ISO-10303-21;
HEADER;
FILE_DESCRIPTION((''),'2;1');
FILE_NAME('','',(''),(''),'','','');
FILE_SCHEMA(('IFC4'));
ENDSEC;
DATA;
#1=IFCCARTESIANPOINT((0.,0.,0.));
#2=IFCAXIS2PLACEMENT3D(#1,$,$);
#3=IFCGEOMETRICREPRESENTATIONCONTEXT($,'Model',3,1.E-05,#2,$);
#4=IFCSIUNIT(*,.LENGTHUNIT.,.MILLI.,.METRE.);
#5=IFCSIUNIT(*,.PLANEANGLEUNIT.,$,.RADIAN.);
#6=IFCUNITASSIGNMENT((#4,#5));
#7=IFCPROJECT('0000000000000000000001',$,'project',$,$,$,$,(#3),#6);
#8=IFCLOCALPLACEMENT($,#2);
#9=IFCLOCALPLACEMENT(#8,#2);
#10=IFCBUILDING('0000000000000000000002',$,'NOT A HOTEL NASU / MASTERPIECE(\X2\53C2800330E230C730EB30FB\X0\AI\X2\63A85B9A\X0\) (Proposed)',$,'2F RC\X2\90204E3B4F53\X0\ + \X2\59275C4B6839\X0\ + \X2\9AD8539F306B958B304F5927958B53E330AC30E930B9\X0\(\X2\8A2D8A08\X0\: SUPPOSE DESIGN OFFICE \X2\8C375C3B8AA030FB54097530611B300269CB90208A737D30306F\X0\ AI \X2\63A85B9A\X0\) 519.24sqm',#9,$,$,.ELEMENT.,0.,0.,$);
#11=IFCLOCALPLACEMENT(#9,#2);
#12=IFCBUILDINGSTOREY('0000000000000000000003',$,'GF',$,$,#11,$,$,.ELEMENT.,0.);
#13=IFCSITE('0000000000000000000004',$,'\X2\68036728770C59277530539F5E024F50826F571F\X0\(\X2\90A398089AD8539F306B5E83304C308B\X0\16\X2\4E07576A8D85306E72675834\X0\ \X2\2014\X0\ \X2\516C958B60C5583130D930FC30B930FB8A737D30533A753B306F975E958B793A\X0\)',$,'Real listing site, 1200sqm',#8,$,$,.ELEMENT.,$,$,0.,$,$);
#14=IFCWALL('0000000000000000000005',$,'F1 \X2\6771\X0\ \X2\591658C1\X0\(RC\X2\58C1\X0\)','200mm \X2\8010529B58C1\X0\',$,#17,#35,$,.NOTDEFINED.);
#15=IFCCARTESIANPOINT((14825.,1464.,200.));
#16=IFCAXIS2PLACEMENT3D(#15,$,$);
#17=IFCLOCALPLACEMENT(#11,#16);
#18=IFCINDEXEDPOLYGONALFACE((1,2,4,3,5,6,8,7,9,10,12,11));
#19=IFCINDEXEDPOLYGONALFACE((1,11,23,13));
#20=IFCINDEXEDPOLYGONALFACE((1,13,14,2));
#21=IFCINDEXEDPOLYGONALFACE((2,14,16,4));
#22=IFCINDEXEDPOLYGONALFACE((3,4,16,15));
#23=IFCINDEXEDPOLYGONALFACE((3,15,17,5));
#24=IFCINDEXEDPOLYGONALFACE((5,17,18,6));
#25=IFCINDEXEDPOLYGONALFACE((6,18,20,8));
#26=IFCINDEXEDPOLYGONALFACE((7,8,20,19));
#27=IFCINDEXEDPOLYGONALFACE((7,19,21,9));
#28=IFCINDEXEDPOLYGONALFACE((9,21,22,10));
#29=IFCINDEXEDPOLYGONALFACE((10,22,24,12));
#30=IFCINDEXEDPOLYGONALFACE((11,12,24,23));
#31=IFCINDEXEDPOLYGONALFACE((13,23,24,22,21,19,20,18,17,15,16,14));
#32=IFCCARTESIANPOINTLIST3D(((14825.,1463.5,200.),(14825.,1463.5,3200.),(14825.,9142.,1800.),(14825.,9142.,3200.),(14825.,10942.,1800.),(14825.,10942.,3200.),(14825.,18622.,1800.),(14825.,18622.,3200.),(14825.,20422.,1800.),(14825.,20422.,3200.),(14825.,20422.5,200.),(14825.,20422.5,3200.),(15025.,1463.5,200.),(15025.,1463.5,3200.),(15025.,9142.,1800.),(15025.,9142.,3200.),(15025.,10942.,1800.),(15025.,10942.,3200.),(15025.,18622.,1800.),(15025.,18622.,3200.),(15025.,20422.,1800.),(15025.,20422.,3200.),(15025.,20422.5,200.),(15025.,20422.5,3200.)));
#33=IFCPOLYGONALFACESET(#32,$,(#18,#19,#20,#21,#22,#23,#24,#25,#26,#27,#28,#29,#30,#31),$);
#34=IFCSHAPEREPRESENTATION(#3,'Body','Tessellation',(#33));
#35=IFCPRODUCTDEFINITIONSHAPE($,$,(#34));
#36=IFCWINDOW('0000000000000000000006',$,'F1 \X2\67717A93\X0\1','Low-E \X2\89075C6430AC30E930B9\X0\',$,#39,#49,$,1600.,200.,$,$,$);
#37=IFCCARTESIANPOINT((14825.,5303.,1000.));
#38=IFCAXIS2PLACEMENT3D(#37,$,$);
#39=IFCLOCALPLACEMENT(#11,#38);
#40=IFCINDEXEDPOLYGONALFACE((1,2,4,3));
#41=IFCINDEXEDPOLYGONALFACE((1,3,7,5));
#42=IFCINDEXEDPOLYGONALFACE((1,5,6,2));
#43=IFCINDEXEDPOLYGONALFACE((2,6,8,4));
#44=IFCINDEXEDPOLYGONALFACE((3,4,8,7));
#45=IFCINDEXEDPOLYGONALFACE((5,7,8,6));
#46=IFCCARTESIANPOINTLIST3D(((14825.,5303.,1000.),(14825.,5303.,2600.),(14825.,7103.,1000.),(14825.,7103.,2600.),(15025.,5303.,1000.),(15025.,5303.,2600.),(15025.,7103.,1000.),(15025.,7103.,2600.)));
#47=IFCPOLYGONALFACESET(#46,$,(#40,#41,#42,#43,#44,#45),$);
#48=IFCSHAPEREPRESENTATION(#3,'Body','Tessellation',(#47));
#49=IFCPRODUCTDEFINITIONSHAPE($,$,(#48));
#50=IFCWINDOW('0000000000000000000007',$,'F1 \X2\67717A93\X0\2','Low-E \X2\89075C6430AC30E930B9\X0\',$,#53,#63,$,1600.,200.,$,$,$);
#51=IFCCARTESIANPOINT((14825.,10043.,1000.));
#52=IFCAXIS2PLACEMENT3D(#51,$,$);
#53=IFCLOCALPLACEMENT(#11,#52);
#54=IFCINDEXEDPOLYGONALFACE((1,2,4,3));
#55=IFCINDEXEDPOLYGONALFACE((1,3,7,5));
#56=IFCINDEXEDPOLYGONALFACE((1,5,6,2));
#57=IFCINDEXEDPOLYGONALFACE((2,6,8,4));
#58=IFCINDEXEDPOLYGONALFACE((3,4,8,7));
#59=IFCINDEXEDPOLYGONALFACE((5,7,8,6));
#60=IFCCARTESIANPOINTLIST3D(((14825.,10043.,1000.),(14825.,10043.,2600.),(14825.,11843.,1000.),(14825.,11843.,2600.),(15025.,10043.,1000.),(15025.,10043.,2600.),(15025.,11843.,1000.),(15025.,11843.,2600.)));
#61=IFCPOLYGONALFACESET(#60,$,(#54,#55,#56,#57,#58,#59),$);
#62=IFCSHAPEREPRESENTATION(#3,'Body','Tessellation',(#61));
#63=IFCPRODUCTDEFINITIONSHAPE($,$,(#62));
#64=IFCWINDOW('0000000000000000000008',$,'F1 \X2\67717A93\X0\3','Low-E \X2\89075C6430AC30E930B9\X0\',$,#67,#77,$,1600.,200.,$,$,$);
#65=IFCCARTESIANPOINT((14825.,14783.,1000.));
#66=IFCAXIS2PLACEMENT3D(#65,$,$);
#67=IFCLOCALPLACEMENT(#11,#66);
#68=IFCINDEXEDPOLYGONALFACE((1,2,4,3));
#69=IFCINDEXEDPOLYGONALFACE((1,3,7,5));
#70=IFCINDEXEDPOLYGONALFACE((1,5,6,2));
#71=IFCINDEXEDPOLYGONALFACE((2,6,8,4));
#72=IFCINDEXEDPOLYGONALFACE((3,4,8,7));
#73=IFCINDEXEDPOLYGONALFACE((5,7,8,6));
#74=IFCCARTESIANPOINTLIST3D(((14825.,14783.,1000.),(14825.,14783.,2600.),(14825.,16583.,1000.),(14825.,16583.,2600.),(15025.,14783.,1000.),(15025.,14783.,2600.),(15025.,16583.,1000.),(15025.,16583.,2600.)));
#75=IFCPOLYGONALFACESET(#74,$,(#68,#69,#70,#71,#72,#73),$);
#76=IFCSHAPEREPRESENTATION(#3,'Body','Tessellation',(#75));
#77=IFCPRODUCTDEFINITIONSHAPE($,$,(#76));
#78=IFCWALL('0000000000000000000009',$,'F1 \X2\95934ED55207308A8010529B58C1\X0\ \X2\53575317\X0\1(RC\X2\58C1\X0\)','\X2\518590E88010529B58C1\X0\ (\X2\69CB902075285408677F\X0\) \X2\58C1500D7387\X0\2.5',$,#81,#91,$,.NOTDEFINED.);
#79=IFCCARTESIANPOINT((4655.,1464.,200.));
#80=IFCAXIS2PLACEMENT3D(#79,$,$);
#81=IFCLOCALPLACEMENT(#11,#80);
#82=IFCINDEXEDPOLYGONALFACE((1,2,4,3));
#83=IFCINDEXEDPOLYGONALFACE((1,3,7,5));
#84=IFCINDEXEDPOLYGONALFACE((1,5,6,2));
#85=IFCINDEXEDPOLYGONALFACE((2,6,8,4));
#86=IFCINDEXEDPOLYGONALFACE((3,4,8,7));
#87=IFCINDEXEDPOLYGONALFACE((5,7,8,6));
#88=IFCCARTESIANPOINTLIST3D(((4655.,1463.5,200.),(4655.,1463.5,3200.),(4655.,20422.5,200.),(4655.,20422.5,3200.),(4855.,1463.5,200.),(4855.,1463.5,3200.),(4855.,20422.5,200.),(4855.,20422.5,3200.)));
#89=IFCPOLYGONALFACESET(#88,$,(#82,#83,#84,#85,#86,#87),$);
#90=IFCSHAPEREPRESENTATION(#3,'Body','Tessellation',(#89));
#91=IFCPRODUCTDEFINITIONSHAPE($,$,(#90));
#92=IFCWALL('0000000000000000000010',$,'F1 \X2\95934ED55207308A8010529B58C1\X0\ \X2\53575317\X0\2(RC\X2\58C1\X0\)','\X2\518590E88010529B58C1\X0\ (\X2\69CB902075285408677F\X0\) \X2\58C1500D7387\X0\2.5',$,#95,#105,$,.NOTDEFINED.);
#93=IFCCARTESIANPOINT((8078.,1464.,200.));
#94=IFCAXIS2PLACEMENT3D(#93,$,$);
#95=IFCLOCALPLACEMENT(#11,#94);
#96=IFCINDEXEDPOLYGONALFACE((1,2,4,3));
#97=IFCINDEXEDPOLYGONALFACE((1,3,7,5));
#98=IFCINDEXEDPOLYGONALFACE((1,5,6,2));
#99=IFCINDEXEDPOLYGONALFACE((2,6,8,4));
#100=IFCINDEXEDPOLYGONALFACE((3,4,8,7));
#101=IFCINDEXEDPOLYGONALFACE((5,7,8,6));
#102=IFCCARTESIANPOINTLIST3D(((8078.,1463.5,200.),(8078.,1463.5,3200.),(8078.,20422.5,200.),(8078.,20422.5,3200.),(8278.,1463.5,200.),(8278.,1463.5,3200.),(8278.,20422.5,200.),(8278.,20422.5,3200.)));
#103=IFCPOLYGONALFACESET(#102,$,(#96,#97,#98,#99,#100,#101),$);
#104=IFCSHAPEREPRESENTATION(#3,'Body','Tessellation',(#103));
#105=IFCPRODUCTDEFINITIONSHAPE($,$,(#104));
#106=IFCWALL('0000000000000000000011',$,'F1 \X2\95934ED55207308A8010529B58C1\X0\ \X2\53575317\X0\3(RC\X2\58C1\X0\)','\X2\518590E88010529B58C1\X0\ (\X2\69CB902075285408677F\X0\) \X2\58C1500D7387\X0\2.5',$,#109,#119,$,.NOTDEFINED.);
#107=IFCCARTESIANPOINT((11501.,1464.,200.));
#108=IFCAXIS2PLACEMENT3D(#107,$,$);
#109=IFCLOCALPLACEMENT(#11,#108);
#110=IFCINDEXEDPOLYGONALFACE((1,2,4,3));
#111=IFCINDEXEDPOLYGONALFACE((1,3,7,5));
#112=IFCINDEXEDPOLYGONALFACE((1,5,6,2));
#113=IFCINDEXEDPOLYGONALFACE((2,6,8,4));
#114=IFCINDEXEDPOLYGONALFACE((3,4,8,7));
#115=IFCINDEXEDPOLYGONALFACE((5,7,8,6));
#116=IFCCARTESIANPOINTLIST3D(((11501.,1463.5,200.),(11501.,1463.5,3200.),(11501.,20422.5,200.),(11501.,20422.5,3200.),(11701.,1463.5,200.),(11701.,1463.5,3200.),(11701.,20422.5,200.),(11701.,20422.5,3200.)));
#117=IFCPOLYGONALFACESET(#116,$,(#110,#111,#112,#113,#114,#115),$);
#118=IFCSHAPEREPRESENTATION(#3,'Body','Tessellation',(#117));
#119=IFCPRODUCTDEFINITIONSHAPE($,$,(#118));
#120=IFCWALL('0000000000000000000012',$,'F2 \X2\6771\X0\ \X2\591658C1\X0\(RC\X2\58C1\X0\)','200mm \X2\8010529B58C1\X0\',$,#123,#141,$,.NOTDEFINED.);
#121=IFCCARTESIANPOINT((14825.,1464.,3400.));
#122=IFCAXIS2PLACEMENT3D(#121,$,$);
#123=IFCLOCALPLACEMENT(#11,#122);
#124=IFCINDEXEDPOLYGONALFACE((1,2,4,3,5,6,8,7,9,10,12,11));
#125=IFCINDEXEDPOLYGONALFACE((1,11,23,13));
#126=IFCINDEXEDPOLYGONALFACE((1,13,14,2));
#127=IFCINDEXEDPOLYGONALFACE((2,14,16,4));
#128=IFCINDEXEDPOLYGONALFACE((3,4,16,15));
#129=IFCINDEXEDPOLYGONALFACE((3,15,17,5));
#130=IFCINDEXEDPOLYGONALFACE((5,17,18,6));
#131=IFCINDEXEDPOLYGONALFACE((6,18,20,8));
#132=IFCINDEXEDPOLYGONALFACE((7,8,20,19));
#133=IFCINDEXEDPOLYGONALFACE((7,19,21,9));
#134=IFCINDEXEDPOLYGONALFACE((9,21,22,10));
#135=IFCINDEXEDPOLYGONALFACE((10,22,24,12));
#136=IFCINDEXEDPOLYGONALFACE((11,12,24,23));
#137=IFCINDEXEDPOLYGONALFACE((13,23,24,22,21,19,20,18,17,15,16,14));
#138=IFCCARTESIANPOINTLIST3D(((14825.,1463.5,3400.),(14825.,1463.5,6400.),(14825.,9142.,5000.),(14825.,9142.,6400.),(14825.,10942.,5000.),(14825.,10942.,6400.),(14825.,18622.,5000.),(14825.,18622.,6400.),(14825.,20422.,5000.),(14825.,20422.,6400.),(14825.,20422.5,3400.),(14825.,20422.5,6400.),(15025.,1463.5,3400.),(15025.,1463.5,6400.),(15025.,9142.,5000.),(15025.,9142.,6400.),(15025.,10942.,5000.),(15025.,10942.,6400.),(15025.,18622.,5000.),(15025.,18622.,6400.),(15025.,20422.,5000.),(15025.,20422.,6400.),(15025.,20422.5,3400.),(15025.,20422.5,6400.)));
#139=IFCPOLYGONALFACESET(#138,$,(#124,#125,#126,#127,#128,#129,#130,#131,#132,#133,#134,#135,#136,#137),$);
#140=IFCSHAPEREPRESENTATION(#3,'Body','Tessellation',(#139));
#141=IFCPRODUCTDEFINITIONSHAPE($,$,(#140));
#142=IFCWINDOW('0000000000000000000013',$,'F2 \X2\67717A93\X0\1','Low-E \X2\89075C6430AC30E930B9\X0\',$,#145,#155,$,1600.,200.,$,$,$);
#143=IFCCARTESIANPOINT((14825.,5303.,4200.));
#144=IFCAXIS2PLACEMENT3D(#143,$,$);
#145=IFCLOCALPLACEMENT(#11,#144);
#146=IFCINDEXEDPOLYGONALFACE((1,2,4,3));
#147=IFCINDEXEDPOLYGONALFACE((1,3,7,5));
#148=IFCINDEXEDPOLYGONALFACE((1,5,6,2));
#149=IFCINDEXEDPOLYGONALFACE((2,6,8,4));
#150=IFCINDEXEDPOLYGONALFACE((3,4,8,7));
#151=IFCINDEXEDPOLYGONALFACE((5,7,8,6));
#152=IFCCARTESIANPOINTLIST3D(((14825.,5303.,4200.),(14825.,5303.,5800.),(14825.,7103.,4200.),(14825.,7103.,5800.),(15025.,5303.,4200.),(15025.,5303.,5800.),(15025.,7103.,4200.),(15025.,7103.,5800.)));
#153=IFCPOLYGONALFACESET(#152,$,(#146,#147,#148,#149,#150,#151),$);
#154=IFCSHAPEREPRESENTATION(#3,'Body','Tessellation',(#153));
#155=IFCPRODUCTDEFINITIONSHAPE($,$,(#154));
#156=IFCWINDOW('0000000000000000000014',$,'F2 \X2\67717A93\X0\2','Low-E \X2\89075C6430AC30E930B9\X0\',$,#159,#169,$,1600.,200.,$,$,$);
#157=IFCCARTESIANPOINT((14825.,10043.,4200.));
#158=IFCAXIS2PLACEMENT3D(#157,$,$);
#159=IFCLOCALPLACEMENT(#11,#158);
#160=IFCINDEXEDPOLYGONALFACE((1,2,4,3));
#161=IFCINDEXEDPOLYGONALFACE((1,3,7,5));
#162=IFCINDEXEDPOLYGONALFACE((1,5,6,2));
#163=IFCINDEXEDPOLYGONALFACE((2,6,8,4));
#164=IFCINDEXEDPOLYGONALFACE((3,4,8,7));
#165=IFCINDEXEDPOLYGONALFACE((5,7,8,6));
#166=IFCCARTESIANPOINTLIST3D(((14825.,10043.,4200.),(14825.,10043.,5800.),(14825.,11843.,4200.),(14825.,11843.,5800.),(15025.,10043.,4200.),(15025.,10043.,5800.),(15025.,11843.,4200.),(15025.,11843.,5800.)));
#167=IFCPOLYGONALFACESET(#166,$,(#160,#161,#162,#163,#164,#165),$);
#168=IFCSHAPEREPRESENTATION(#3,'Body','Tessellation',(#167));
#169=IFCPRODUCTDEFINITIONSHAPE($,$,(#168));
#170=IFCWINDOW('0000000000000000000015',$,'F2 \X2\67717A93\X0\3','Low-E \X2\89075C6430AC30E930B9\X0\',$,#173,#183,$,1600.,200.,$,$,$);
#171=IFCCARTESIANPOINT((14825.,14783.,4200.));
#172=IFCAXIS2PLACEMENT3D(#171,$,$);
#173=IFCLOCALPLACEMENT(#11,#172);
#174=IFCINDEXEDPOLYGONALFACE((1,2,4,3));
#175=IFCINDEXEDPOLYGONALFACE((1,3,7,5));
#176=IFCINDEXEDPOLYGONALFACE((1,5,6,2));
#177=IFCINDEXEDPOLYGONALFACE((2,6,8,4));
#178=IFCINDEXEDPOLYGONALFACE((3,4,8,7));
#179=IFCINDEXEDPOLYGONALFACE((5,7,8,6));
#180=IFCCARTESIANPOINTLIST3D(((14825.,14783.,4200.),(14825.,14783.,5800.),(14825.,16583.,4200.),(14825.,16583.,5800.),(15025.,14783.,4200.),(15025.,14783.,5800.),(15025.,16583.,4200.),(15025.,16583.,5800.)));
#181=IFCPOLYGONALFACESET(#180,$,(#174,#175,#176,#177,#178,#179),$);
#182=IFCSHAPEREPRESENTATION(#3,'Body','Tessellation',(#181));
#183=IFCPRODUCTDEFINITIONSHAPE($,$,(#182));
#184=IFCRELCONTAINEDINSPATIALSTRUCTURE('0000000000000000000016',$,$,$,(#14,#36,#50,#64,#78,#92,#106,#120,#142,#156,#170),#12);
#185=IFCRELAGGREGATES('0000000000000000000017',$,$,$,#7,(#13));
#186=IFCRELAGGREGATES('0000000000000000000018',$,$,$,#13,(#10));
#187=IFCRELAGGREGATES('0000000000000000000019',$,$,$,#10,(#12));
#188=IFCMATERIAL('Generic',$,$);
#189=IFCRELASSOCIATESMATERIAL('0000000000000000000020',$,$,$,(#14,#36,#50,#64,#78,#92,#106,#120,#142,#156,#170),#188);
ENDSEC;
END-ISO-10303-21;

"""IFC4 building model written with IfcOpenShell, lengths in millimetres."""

from ifc_helpers import new_model, si_unit, frame, frame_2d, origin, place, context, project, spatial, rectangle, extrude, material, element, fill, save


model = new_model("IFC4")

# Units and contexts
model_context = context("Model", 3, precision=1e-05, world=origin())
ifc_project = project(units=[si_unit("LENGTHUNIT", "METRE", prefix="MILLI"), si_unit("PLANEANGLEUNIT", "RADIAN")], contexts=[model_context])

# Site, building, storey
site_placement = place(None, origin())
site = spatial("IfcSite", under=ifc_project, at=site_placement, Name="栃木県大田原市佐良土(那須高原に広がる16万坪超の牧場 — 公開情報ベース・詳細区画は非開示)", ObjectType="Real listing site, 1200sqm", CompositionType="ELEMENT", RefElevation=0.0)
building_placement = place(site_placement, origin())
building = spatial("IfcBuilding", under=site, at=building_placement, Name="NOT A HOTEL NASU / MASTERPIECE(参考モデル・AI推定) (Proposed)", ObjectType="2F RC造主体 + 大屋根 + 高原に開く大開口ガラス(設計: SUPPOSE DESIGN OFFICE 谷尻誠・吉田愛。構造詳細は AI 推定) 519.24sqm", CompositionType="ELEMENT", ElevationOfRefHeight=0.0, ElevationOfTerrain=0.0)
storey_placement = place(building_placement, origin())
storey = spatial("IfcBuildingStorey", under=building, at=storey_placement, Name="GF", CompositionType="ELEMENT", Elevation=0.0)

# Wall, openings, windows
ifc_material = material(Name="Generic")
wall_1_placement = place(storey_placement, frame((14825.0, 1464.0, 200.0)))
wall_1 = element("IfcWall", 1, at=wall_1_placement, inside=storey, material=ifc_material, Name="F1 東 外壁(RC壁)", Description="200mm 耐力壁", PredefinedType="NOTDEFINED", context=model_context, shape_type="SweptSolid", body=[
    extrude(rectangle(XDim=200.0, YDim=18959.0, at=frame_2d((100.0, 9479.0))), frame((14825.0, 1464.0, 200.0)), (0.0, 0.0, 1.0), 3000.0),
])
opening_1_placement = place(storey_placement, frame((14825.0, 5303.0, 1000.0)))
opening_1 = element("IfcOpeningElement", 2, at=opening_1_placement, cuts=wall_1, PredefinedType="NOTDEFINED", context=model_context, shape_type="SweptSolid", body=[
    extrude(rectangle(XDim=200.0, YDim=1800.0, at=frame_2d((100.0, 900.0))), frame((14825.0, 5303.0, 1000.0)), (0.0, 0.0, 1.0), 1600.0),
])
opening_2_placement = place(storey_placement, frame((14825.0, 10043.0, 1000.0)))
opening_2 = element("IfcOpeningElement", 3, at=opening_2_placement, cuts=wall_1, PredefinedType="NOTDEFINED", context=model_context, shape_type="SweptSolid", body=[
    extrude(rectangle(XDim=200.0, YDim=1800.0, at=frame_2d((100.0, 900.0))), frame((14825.0, 10043.0, 1000.0)), (0.0, 0.0, 1.0), 1600.0),
])
opening_3_placement = place(storey_placement, frame((14825.0, 14783.0, 1000.0)))
opening_3 = element("IfcOpeningElement", 4, at=opening_3_placement, cuts=wall_1, PredefinedType="NOTDEFINED", context=model_context, shape_type="SweptSolid", body=[
    extrude(rectangle(XDim=200.0, YDim=1800.0, at=frame_2d((100.0, 900.0))), frame((14825.0, 14783.0, 1000.0)), (0.0, 0.0, 1.0), 1600.0),
])
window_1_placement = place(storey_placement, frame((14825.0, 5303.0, 1000.0)))
window_1 = element("IfcWindow", 5, at=window_1_placement, inside=storey, material=ifc_material, Name="F1 東窓1", Description="Low-E 複層ガラス", OverallHeight=1600.0, OverallWidth=200.0, context=model_context, shape_type="SweptSolid", body=[
    extrude(rectangle(XDim=200.0, YDim=1800.0, at=frame_2d((100.0, 900.0))), frame((14825.0, 5303.0, 1000.0)), (0.0, 0.0, 1.0), 1600.0),
])
fill(opening_1, window_1)
window_2_placement = place(storey_placement, frame((14825.0, 10043.0, 1000.0)))
window_2 = element("IfcWindow", 6, at=window_2_placement, inside=storey, material=ifc_material, Name="F1 東窓2", Description="Low-E 複層ガラス", OverallHeight=1600.0, OverallWidth=200.0, context=model_context, shape_type="SweptSolid", body=[
    extrude(rectangle(XDim=200.0, YDim=1800.0, at=frame_2d((100.0, 900.0))), frame((14825.0, 10043.0, 1000.0)), (0.0, 0.0, 1.0), 1600.0),
])
fill(opening_2, window_2)
window_3_placement = place(storey_placement, frame((14825.0, 14783.0, 1000.0)))
window_3 = element("IfcWindow", 7, at=window_3_placement, inside=storey, material=ifc_material, Name="F1 東窓3", Description="Low-E 複層ガラス", OverallHeight=1600.0, OverallWidth=200.0, context=model_context, shape_type="SweptSolid", body=[
    extrude(rectangle(XDim=200.0, YDim=1800.0, at=frame_2d((100.0, 900.0))), frame((14825.0, 14783.0, 1000.0)), (0.0, 0.0, 1.0), 1600.0),
])
fill(opening_3, window_3)

# Walls
wall_2_placement = place(storey_placement, frame((4655.0, 1464.0, 200.0)))
element("IfcWall", 8, at=wall_2_placement, inside=storey, material=ifc_material, Name="F1 間仕切り耐力壁 南北1(RC壁)", Description="内部耐力壁 (構造用合板) 壁倍率2.5", PredefinedType="NOTDEFINED", context=model_context, shape_type="SweptSolid", body=[
    extrude(rectangle(XDim=200.0, YDim=18959.0, at=frame_2d((100.0, 9479.0))), frame((4655.0, 1464.0, 200.0)), (0.0, 0.0, 1.0), 3000.0),
])
wall_3_placement = place(storey_placement, frame((8078.0, 1464.0, 200.0)))
element("IfcWall", 9, at=wall_3_placement, inside=storey, material=ifc_material, Name="F1 間仕切り耐力壁 南北2(RC壁)", Description="内部耐力壁 (構造用合板) 壁倍率2.5", PredefinedType="NOTDEFINED", context=model_context, shape_type="SweptSolid", body=[
    extrude(rectangle(XDim=200.0, YDim=18959.0, at=frame_2d((100.0, 9479.0))), frame((8078.0, 1464.0, 200.0)), (0.0, 0.0, 1.0), 3000.0),
])
wall_4_placement = place(storey_placement, frame((11501.0, 1464.0, 200.0)))
element("IfcWall", 10, at=wall_4_placement, inside=storey, material=ifc_material, Name="F1 間仕切り耐力壁 南北3(RC壁)", Description="内部耐力壁 (構造用合板) 壁倍率2.5", PredefinedType="NOTDEFINED", context=model_context, shape_type="SweptSolid", body=[
    extrude(rectangle(XDim=200.0, YDim=18959.0, at=frame_2d((100.0, 9479.0))), frame((11501.0, 1464.0, 200.0)), (0.0, 0.0, 1.0), 3000.0),
])

# Wall, openings, windows
wall_5_placement = place(storey_placement, frame((14825.0, 1464.0, 3400.0)))
wall_5 = element("IfcWall", 11, at=wall_5_placement, inside=storey, material=ifc_material, Name="F2 東 外壁(RC壁)", Description="200mm 耐力壁", PredefinedType="NOTDEFINED", context=model_context, shape_type="SweptSolid", body=[
    extrude(rectangle(XDim=200.0, YDim=18959.0, at=frame_2d((100.0, 9479.0))), frame((14825.0, 1464.0, 3400.0)), (0.0, 0.0, 1.0), 3000.0),
])
opening_4_placement = place(storey_placement, frame((14825.0, 5303.0, 4200.0)))
opening_4 = element("IfcOpeningElement", 12, at=opening_4_placement, cuts=wall_5, PredefinedType="NOTDEFINED", context=model_context, shape_type="SweptSolid", body=[
    extrude(rectangle(XDim=200.0, YDim=1800.0, at=frame_2d((100.0, 900.0))), frame((14825.0, 5303.0, 4200.0)), (0.0, 0.0, 1.0), 1600.0),
])
opening_5_placement = place(storey_placement, frame((14825.0, 10043.0, 4200.0)))
opening_5 = element("IfcOpeningElement", 13, at=opening_5_placement, cuts=wall_5, PredefinedType="NOTDEFINED", context=model_context, shape_type="SweptSolid", body=[
    extrude(rectangle(XDim=200.0, YDim=1800.0, at=frame_2d((100.0, 900.0))), frame((14825.0, 10043.0, 4200.0)), (0.0, 0.0, 1.0), 1600.0),
])
opening_6_placement = place(storey_placement, frame((14825.0, 14783.0, 4200.0)))
opening_6 = element("IfcOpeningElement", 14, at=opening_6_placement, cuts=wall_5, PredefinedType="NOTDEFINED", context=model_context, shape_type="SweptSolid", body=[
    extrude(rectangle(XDim=200.0, YDim=1800.0, at=frame_2d((100.0, 900.0))), frame((14825.0, 14783.0, 4200.0)), (0.0, 0.0, 1.0), 1600.0),
])
window_4_placement = place(storey_placement, frame((14825.0, 5303.0, 4200.0)))
window_4 = element("IfcWindow", 15, at=window_4_placement, inside=storey, material=ifc_material, Name="F2 東窓1", Description="Low-E 複層ガラス", OverallHeight=1600.0, OverallWidth=200.0, context=model_context, shape_type="SweptSolid", body=[
    extrude(rectangle(XDim=200.0, YDim=1800.0, at=frame_2d((100.0, 900.0))), frame((14825.0, 5303.0, 4200.0)), (0.0, 0.0, 1.0), 1600.0),
])
fill(opening_4, window_4)
window_5_placement = place(storey_placement, frame((14825.0, 10043.0, 4200.0)))
window_5 = element("IfcWindow", 16, at=window_5_placement, inside=storey, material=ifc_material, Name="F2 東窓2", Description="Low-E 複層ガラス", OverallHeight=1600.0, OverallWidth=200.0, context=model_context, shape_type="SweptSolid", body=[
    extrude(rectangle(XDim=200.0, YDim=1800.0, at=frame_2d((100.0, 900.0))), frame((14825.0, 10043.0, 4200.0)), (0.0, 0.0, 1.0), 1600.0),
])
fill(opening_5, window_5)
window_6_placement = place(storey_placement, frame((14825.0, 14783.0, 4200.0)))
window_6 = element("IfcWindow", 17, at=window_6_placement, inside=storey, material=ifc_material, Name="F2 東窓3", Description="Low-E 複層ガラス", OverallHeight=1600.0, OverallWidth=200.0, context=model_context, shape_type="SweptSolid", body=[
    extrude(rectangle(XDim=200.0, YDim=1800.0, at=frame_2d((100.0, 900.0))), frame((14825.0, 14783.0, 4200.0)), (0.0, 0.0, 1.0), 1600.0),
])
fill(opening_6, window_6)

save(model, "model.ifc")
